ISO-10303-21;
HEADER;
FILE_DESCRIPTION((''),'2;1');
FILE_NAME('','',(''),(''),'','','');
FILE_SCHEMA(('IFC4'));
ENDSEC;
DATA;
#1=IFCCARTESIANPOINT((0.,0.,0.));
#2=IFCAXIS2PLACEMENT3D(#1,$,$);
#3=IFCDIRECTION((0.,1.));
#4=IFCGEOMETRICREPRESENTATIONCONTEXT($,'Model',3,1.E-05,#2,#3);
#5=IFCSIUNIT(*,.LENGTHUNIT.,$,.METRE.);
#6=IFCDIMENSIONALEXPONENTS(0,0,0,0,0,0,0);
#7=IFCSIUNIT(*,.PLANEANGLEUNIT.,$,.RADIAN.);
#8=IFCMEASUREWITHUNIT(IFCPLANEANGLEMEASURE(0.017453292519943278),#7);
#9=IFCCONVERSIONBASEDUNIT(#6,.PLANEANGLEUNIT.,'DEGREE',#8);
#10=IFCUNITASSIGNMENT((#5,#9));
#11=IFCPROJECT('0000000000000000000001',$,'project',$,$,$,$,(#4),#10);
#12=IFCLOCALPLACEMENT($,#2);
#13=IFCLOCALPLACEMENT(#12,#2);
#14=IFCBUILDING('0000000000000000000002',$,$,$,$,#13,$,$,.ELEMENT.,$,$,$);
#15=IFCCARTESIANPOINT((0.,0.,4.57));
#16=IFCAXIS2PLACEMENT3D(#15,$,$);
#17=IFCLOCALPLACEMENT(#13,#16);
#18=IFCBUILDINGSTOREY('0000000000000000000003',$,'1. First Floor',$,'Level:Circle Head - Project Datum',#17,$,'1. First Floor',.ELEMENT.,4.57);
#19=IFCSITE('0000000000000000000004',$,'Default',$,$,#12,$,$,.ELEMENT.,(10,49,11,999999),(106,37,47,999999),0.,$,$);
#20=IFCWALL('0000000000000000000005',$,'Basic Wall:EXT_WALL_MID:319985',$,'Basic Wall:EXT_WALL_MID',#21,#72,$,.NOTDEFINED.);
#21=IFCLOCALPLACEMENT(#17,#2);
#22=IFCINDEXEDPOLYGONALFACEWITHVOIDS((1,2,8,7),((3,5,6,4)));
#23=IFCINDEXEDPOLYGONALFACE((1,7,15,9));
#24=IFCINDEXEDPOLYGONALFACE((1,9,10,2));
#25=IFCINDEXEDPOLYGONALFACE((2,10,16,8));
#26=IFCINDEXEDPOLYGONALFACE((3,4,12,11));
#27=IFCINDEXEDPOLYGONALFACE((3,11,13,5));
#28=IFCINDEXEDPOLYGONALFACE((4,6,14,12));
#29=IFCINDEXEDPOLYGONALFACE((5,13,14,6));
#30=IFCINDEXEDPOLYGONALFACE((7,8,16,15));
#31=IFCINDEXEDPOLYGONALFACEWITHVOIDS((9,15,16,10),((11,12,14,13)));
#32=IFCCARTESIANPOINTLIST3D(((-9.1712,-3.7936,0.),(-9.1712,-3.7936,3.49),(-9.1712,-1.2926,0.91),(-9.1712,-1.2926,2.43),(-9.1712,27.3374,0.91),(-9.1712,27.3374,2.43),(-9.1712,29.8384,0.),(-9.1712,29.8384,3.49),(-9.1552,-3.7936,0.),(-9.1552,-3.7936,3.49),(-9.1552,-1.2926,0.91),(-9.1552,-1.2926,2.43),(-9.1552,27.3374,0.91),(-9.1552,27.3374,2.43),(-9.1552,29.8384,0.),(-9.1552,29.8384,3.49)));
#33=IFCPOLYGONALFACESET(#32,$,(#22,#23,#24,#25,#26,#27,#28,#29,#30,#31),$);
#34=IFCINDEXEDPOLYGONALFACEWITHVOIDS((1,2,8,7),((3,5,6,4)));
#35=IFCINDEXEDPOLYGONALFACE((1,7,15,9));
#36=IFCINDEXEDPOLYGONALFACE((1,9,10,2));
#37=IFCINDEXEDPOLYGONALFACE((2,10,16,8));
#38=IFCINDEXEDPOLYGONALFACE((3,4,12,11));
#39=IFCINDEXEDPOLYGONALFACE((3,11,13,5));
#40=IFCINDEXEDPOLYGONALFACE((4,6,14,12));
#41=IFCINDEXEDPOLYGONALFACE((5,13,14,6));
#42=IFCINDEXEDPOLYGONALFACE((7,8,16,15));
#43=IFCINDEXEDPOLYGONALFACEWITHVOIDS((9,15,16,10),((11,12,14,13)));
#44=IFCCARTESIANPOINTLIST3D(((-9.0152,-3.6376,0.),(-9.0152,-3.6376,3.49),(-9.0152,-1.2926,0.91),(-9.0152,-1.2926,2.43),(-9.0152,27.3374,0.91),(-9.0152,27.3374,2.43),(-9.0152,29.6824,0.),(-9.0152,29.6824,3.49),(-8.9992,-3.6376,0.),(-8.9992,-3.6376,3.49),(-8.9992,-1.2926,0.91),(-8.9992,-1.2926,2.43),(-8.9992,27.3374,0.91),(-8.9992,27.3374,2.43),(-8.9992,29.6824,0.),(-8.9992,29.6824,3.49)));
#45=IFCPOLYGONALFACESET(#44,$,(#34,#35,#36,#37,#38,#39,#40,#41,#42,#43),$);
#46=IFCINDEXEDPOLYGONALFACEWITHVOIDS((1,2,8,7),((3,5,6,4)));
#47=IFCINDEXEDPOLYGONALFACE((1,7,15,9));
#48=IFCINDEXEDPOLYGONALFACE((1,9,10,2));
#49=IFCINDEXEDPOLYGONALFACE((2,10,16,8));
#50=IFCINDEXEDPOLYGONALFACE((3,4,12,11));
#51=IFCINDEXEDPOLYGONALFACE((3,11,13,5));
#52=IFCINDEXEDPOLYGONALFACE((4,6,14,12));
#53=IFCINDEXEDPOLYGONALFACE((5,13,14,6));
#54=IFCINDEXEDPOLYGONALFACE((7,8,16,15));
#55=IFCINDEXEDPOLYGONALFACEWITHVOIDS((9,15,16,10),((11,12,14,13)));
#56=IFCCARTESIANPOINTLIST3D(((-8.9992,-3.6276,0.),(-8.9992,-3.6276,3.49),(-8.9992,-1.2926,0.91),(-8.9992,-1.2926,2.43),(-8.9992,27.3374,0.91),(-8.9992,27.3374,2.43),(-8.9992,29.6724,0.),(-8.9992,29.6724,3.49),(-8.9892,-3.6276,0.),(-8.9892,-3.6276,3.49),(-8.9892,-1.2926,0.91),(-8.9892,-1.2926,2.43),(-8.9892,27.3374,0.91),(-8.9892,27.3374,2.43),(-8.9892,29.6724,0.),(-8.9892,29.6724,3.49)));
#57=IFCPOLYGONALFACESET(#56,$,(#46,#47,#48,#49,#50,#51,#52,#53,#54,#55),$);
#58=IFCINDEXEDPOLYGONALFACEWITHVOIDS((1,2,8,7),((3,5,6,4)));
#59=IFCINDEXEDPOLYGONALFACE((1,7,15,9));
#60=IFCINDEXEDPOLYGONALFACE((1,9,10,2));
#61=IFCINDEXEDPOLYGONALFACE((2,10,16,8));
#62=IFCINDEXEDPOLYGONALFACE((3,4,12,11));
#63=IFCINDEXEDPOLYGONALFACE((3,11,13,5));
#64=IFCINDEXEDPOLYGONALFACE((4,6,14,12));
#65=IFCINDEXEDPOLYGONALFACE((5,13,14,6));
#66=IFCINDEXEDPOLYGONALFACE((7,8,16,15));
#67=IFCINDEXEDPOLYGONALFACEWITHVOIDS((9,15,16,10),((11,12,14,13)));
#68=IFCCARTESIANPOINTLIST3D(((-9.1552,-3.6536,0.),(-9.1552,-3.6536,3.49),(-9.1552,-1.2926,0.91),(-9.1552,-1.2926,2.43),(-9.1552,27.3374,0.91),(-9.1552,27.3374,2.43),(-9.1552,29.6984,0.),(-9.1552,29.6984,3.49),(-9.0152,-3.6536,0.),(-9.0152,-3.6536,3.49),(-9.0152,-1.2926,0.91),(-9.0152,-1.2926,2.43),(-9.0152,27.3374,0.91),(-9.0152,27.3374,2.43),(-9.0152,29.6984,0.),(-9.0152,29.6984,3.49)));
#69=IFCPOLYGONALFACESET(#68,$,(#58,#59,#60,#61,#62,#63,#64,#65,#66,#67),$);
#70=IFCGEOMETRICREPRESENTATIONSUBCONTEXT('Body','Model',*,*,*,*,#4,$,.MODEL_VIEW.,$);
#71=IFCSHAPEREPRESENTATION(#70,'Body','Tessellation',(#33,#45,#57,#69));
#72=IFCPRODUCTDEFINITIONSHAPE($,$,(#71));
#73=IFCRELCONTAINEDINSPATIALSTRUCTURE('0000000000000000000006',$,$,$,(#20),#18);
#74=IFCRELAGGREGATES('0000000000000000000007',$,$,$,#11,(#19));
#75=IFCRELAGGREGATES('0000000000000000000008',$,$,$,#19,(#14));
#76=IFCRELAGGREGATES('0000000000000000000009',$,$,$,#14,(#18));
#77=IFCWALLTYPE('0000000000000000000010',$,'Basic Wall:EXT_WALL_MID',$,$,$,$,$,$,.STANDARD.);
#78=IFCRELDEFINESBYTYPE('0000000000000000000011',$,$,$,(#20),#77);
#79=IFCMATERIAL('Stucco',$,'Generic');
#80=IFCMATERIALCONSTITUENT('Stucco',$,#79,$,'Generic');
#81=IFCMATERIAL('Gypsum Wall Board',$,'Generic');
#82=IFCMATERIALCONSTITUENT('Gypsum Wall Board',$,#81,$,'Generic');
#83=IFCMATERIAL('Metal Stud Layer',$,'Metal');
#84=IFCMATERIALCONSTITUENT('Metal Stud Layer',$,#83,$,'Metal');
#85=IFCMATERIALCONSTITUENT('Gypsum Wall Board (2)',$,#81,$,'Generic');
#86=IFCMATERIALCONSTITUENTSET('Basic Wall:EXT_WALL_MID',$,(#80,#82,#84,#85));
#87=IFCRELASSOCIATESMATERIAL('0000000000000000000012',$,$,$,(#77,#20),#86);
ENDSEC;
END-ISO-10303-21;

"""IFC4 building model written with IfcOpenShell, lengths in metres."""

from ifc_helpers import new_model, entity, si_unit, converted_unit, direction, frame, origin, place, context, subcontext, project, spatial, indexed_curve, outline, extrude, material, constituent, constituent_set, type_object, element, save


model = new_model("IFC4")

# Units and contexts
model_context = context("Model", 3, precision=1e-05, world=origin(), true_north=direction((0.0, 1.0)))
body_context = subcontext(model_context, "Body", "Model", "MODEL_VIEW")
ifc_project = project(units=[si_unit("LENGTHUNIT", "METRE"), converted_unit("PLANEANGLEUNIT", "DEGREE", entity("IfcPlaneAngleMeasure", 0.017453292519943278), si_unit("PLANEANGLEUNIT", "RADIAN"), dimensions=[0, 0, 0, 0, 0, 0, 0])], contexts=[model_context])

# Site, building, storey
site_placement = place(None, origin())
site = spatial("IfcSite", under=ifc_project, at=site_placement, Name="Default", CompositionType="ELEMENT", RefLatitude=(10, 49, 11, 999999), RefLongitude=(106, 37, 47, 999999), RefElevation=0.0)
building_placement = place(site_placement, origin())
building = spatial("IfcBuilding", under=site, at=building_placement, CompositionType="ELEMENT")
storey_placement = place(building_placement, frame((0.0, 0.0, 4.57)))
storey = spatial("IfcBuildingStorey", under=building, at=storey_placement, Name="1. First Floor", ObjectType="Level:Circle Head - Project Datum", LongName="1. First Floor", CompositionType="ELEMENT", Elevation=4.57)

# Shared definitions
ifc_material_1 = material(Name="Stucco", Category="Generic")
ifc_material_2 = material(Name="Gypsum Wall Board", Category="Generic")
ifc_material_3 = material(Name="Metal Stud Layer", Category="Metal")

# Wall, opening
ifc_constituent_1 = constituent(ifc_material_1, Name="Stucco", Category="Generic")
ifc_constituent_2 = constituent(ifc_material_2, Name="Gypsum Wall Board", Category="Generic")
ifc_constituent_3 = constituent(ifc_material_3, Name="Metal Stud Layer", Category="Metal")
ifc_constituent_4 = constituent(ifc_material_2, Name="Gypsum Wall Board (2)", Category="Generic")
ifc_constituent_set_1 = constituent_set(constituents=[ifc_constituent_1, ifc_constituent_2, ifc_constituent_3, ifc_constituent_4], Name="Basic Wall:EXT_WALL_MID")
wall_type_1 = type_object("IfcWallType", Name="Basic Wall:EXT_WALL_MID", PredefinedType="STANDARD", material=ifc_constituent_set_1)
wall_1_placement = place(storey_placement, frame((-9.0802, 29.6724, 0.0), z_axis=(0.0, 0.0, 1.0), x_axis=(0.0, -1.0, 0.0)))
wall_1 = element("IfcWall", 1, at=wall_1_placement, inside=storey, type_object=wall_type_1, material=ifc_constituent_set_1, Name="Basic Wall:EXT_WALL_MID:319985", ObjectType="Basic Wall:EXT_WALL_MID", PredefinedType="NOTDEFINED", context=body_context, shape_type="SweptSolid", body=[
    extrude(outline(indexed_curve([(-1.745, -16.816), (1.745, -16.816), (1.745, 16.816), (-1.745, 16.816), (-1.745, -16.816)], self_intersect=False), holes=[indexed_curve([(0.685, 14.315), (0.685, -14.315), (-0.835, -14.315), (-0.835, 14.315), (0.685, 14.315)], self_intersect=False)]), frame((16.65, -0.091, 1.745), z_axis=(0.0, 1.0, 0.0), x_axis=(0.0, 0.0, 1.0)), (0.0, 0.0, 1.0), 0.016),
    extrude(outline(indexed_curve([(-1.745, -16.66), (1.745, -16.66), (1.745, 16.66), (-1.745, 16.66), (-1.745, -16.66)], self_intersect=False), holes=[indexed_curve([(0.685, 14.315), (0.685, -14.315), (-0.835, -14.315), (-0.835, 14.315), (0.685, 14.315)], self_intersect=False)]), frame((16.65, 0.065, 1.745), z_axis=(0.0, 1.0, 0.0), x_axis=(0.0, 0.0, 1.0)), (0.0, 0.0, 1.0), 0.016),
    extrude(outline(indexed_curve([(-1.745, -16.65), (1.745, -16.65), (1.745, 16.65), (-1.745, 16.65), (-1.745, -16.65)], self_intersect=False), holes=[indexed_curve([(0.685, 14.315), (0.685, -14.315), (-0.835, -14.315), (-0.835, 14.315), (0.685, 14.315)], self_intersect=False)]), frame((16.65, 0.081, 1.745), z_axis=(0.0, 1.0, 0.0), x_axis=(0.0, 0.0, 1.0)), (0.0, 0.0, 1.0), 0.01),
    extrude(outline(indexed_curve([(-1.745, -16.676), (1.745, -16.676), (1.745, 16.676), (-1.745, 16.676), (-1.745, -16.676)], self_intersect=False), holes=[indexed_curve([(0.685, 14.315), (0.685, -14.315), (-0.835, -14.315), (-0.835, 14.315), (0.685, 14.315)], self_intersect=False)]), frame((16.65, -0.075, 1.745), z_axis=(0.0, 1.0, 0.0), x_axis=(0.0, 0.0, 1.0)), (0.0, 0.0, 1.0), 0.14),
])
opening_1_placement = place(wall_1_placement, frame((30.965, 0.091, 0.91)))
element("IfcOpeningElement", 2, at=opening_1_placement, cuts=wall_1, PredefinedType="OPENING", context=body_context, shape_type="SweptSolid", body=[
    extrude(outline(indexed_curve([(1.52, 0.0), (1.52, 28.63), (0.0, 28.63), (0.0, 0.0), (1.52, 0.0)], self_intersect=False)), frame((0.0, 0.0, 0.0), z_axis=(0.0, -1.0, 0.0), x_axis=(0.0, 0.0, 1.0)), (0.0, 0.0, 1.0), 0.182),
])

save(model, "model.ifc")
